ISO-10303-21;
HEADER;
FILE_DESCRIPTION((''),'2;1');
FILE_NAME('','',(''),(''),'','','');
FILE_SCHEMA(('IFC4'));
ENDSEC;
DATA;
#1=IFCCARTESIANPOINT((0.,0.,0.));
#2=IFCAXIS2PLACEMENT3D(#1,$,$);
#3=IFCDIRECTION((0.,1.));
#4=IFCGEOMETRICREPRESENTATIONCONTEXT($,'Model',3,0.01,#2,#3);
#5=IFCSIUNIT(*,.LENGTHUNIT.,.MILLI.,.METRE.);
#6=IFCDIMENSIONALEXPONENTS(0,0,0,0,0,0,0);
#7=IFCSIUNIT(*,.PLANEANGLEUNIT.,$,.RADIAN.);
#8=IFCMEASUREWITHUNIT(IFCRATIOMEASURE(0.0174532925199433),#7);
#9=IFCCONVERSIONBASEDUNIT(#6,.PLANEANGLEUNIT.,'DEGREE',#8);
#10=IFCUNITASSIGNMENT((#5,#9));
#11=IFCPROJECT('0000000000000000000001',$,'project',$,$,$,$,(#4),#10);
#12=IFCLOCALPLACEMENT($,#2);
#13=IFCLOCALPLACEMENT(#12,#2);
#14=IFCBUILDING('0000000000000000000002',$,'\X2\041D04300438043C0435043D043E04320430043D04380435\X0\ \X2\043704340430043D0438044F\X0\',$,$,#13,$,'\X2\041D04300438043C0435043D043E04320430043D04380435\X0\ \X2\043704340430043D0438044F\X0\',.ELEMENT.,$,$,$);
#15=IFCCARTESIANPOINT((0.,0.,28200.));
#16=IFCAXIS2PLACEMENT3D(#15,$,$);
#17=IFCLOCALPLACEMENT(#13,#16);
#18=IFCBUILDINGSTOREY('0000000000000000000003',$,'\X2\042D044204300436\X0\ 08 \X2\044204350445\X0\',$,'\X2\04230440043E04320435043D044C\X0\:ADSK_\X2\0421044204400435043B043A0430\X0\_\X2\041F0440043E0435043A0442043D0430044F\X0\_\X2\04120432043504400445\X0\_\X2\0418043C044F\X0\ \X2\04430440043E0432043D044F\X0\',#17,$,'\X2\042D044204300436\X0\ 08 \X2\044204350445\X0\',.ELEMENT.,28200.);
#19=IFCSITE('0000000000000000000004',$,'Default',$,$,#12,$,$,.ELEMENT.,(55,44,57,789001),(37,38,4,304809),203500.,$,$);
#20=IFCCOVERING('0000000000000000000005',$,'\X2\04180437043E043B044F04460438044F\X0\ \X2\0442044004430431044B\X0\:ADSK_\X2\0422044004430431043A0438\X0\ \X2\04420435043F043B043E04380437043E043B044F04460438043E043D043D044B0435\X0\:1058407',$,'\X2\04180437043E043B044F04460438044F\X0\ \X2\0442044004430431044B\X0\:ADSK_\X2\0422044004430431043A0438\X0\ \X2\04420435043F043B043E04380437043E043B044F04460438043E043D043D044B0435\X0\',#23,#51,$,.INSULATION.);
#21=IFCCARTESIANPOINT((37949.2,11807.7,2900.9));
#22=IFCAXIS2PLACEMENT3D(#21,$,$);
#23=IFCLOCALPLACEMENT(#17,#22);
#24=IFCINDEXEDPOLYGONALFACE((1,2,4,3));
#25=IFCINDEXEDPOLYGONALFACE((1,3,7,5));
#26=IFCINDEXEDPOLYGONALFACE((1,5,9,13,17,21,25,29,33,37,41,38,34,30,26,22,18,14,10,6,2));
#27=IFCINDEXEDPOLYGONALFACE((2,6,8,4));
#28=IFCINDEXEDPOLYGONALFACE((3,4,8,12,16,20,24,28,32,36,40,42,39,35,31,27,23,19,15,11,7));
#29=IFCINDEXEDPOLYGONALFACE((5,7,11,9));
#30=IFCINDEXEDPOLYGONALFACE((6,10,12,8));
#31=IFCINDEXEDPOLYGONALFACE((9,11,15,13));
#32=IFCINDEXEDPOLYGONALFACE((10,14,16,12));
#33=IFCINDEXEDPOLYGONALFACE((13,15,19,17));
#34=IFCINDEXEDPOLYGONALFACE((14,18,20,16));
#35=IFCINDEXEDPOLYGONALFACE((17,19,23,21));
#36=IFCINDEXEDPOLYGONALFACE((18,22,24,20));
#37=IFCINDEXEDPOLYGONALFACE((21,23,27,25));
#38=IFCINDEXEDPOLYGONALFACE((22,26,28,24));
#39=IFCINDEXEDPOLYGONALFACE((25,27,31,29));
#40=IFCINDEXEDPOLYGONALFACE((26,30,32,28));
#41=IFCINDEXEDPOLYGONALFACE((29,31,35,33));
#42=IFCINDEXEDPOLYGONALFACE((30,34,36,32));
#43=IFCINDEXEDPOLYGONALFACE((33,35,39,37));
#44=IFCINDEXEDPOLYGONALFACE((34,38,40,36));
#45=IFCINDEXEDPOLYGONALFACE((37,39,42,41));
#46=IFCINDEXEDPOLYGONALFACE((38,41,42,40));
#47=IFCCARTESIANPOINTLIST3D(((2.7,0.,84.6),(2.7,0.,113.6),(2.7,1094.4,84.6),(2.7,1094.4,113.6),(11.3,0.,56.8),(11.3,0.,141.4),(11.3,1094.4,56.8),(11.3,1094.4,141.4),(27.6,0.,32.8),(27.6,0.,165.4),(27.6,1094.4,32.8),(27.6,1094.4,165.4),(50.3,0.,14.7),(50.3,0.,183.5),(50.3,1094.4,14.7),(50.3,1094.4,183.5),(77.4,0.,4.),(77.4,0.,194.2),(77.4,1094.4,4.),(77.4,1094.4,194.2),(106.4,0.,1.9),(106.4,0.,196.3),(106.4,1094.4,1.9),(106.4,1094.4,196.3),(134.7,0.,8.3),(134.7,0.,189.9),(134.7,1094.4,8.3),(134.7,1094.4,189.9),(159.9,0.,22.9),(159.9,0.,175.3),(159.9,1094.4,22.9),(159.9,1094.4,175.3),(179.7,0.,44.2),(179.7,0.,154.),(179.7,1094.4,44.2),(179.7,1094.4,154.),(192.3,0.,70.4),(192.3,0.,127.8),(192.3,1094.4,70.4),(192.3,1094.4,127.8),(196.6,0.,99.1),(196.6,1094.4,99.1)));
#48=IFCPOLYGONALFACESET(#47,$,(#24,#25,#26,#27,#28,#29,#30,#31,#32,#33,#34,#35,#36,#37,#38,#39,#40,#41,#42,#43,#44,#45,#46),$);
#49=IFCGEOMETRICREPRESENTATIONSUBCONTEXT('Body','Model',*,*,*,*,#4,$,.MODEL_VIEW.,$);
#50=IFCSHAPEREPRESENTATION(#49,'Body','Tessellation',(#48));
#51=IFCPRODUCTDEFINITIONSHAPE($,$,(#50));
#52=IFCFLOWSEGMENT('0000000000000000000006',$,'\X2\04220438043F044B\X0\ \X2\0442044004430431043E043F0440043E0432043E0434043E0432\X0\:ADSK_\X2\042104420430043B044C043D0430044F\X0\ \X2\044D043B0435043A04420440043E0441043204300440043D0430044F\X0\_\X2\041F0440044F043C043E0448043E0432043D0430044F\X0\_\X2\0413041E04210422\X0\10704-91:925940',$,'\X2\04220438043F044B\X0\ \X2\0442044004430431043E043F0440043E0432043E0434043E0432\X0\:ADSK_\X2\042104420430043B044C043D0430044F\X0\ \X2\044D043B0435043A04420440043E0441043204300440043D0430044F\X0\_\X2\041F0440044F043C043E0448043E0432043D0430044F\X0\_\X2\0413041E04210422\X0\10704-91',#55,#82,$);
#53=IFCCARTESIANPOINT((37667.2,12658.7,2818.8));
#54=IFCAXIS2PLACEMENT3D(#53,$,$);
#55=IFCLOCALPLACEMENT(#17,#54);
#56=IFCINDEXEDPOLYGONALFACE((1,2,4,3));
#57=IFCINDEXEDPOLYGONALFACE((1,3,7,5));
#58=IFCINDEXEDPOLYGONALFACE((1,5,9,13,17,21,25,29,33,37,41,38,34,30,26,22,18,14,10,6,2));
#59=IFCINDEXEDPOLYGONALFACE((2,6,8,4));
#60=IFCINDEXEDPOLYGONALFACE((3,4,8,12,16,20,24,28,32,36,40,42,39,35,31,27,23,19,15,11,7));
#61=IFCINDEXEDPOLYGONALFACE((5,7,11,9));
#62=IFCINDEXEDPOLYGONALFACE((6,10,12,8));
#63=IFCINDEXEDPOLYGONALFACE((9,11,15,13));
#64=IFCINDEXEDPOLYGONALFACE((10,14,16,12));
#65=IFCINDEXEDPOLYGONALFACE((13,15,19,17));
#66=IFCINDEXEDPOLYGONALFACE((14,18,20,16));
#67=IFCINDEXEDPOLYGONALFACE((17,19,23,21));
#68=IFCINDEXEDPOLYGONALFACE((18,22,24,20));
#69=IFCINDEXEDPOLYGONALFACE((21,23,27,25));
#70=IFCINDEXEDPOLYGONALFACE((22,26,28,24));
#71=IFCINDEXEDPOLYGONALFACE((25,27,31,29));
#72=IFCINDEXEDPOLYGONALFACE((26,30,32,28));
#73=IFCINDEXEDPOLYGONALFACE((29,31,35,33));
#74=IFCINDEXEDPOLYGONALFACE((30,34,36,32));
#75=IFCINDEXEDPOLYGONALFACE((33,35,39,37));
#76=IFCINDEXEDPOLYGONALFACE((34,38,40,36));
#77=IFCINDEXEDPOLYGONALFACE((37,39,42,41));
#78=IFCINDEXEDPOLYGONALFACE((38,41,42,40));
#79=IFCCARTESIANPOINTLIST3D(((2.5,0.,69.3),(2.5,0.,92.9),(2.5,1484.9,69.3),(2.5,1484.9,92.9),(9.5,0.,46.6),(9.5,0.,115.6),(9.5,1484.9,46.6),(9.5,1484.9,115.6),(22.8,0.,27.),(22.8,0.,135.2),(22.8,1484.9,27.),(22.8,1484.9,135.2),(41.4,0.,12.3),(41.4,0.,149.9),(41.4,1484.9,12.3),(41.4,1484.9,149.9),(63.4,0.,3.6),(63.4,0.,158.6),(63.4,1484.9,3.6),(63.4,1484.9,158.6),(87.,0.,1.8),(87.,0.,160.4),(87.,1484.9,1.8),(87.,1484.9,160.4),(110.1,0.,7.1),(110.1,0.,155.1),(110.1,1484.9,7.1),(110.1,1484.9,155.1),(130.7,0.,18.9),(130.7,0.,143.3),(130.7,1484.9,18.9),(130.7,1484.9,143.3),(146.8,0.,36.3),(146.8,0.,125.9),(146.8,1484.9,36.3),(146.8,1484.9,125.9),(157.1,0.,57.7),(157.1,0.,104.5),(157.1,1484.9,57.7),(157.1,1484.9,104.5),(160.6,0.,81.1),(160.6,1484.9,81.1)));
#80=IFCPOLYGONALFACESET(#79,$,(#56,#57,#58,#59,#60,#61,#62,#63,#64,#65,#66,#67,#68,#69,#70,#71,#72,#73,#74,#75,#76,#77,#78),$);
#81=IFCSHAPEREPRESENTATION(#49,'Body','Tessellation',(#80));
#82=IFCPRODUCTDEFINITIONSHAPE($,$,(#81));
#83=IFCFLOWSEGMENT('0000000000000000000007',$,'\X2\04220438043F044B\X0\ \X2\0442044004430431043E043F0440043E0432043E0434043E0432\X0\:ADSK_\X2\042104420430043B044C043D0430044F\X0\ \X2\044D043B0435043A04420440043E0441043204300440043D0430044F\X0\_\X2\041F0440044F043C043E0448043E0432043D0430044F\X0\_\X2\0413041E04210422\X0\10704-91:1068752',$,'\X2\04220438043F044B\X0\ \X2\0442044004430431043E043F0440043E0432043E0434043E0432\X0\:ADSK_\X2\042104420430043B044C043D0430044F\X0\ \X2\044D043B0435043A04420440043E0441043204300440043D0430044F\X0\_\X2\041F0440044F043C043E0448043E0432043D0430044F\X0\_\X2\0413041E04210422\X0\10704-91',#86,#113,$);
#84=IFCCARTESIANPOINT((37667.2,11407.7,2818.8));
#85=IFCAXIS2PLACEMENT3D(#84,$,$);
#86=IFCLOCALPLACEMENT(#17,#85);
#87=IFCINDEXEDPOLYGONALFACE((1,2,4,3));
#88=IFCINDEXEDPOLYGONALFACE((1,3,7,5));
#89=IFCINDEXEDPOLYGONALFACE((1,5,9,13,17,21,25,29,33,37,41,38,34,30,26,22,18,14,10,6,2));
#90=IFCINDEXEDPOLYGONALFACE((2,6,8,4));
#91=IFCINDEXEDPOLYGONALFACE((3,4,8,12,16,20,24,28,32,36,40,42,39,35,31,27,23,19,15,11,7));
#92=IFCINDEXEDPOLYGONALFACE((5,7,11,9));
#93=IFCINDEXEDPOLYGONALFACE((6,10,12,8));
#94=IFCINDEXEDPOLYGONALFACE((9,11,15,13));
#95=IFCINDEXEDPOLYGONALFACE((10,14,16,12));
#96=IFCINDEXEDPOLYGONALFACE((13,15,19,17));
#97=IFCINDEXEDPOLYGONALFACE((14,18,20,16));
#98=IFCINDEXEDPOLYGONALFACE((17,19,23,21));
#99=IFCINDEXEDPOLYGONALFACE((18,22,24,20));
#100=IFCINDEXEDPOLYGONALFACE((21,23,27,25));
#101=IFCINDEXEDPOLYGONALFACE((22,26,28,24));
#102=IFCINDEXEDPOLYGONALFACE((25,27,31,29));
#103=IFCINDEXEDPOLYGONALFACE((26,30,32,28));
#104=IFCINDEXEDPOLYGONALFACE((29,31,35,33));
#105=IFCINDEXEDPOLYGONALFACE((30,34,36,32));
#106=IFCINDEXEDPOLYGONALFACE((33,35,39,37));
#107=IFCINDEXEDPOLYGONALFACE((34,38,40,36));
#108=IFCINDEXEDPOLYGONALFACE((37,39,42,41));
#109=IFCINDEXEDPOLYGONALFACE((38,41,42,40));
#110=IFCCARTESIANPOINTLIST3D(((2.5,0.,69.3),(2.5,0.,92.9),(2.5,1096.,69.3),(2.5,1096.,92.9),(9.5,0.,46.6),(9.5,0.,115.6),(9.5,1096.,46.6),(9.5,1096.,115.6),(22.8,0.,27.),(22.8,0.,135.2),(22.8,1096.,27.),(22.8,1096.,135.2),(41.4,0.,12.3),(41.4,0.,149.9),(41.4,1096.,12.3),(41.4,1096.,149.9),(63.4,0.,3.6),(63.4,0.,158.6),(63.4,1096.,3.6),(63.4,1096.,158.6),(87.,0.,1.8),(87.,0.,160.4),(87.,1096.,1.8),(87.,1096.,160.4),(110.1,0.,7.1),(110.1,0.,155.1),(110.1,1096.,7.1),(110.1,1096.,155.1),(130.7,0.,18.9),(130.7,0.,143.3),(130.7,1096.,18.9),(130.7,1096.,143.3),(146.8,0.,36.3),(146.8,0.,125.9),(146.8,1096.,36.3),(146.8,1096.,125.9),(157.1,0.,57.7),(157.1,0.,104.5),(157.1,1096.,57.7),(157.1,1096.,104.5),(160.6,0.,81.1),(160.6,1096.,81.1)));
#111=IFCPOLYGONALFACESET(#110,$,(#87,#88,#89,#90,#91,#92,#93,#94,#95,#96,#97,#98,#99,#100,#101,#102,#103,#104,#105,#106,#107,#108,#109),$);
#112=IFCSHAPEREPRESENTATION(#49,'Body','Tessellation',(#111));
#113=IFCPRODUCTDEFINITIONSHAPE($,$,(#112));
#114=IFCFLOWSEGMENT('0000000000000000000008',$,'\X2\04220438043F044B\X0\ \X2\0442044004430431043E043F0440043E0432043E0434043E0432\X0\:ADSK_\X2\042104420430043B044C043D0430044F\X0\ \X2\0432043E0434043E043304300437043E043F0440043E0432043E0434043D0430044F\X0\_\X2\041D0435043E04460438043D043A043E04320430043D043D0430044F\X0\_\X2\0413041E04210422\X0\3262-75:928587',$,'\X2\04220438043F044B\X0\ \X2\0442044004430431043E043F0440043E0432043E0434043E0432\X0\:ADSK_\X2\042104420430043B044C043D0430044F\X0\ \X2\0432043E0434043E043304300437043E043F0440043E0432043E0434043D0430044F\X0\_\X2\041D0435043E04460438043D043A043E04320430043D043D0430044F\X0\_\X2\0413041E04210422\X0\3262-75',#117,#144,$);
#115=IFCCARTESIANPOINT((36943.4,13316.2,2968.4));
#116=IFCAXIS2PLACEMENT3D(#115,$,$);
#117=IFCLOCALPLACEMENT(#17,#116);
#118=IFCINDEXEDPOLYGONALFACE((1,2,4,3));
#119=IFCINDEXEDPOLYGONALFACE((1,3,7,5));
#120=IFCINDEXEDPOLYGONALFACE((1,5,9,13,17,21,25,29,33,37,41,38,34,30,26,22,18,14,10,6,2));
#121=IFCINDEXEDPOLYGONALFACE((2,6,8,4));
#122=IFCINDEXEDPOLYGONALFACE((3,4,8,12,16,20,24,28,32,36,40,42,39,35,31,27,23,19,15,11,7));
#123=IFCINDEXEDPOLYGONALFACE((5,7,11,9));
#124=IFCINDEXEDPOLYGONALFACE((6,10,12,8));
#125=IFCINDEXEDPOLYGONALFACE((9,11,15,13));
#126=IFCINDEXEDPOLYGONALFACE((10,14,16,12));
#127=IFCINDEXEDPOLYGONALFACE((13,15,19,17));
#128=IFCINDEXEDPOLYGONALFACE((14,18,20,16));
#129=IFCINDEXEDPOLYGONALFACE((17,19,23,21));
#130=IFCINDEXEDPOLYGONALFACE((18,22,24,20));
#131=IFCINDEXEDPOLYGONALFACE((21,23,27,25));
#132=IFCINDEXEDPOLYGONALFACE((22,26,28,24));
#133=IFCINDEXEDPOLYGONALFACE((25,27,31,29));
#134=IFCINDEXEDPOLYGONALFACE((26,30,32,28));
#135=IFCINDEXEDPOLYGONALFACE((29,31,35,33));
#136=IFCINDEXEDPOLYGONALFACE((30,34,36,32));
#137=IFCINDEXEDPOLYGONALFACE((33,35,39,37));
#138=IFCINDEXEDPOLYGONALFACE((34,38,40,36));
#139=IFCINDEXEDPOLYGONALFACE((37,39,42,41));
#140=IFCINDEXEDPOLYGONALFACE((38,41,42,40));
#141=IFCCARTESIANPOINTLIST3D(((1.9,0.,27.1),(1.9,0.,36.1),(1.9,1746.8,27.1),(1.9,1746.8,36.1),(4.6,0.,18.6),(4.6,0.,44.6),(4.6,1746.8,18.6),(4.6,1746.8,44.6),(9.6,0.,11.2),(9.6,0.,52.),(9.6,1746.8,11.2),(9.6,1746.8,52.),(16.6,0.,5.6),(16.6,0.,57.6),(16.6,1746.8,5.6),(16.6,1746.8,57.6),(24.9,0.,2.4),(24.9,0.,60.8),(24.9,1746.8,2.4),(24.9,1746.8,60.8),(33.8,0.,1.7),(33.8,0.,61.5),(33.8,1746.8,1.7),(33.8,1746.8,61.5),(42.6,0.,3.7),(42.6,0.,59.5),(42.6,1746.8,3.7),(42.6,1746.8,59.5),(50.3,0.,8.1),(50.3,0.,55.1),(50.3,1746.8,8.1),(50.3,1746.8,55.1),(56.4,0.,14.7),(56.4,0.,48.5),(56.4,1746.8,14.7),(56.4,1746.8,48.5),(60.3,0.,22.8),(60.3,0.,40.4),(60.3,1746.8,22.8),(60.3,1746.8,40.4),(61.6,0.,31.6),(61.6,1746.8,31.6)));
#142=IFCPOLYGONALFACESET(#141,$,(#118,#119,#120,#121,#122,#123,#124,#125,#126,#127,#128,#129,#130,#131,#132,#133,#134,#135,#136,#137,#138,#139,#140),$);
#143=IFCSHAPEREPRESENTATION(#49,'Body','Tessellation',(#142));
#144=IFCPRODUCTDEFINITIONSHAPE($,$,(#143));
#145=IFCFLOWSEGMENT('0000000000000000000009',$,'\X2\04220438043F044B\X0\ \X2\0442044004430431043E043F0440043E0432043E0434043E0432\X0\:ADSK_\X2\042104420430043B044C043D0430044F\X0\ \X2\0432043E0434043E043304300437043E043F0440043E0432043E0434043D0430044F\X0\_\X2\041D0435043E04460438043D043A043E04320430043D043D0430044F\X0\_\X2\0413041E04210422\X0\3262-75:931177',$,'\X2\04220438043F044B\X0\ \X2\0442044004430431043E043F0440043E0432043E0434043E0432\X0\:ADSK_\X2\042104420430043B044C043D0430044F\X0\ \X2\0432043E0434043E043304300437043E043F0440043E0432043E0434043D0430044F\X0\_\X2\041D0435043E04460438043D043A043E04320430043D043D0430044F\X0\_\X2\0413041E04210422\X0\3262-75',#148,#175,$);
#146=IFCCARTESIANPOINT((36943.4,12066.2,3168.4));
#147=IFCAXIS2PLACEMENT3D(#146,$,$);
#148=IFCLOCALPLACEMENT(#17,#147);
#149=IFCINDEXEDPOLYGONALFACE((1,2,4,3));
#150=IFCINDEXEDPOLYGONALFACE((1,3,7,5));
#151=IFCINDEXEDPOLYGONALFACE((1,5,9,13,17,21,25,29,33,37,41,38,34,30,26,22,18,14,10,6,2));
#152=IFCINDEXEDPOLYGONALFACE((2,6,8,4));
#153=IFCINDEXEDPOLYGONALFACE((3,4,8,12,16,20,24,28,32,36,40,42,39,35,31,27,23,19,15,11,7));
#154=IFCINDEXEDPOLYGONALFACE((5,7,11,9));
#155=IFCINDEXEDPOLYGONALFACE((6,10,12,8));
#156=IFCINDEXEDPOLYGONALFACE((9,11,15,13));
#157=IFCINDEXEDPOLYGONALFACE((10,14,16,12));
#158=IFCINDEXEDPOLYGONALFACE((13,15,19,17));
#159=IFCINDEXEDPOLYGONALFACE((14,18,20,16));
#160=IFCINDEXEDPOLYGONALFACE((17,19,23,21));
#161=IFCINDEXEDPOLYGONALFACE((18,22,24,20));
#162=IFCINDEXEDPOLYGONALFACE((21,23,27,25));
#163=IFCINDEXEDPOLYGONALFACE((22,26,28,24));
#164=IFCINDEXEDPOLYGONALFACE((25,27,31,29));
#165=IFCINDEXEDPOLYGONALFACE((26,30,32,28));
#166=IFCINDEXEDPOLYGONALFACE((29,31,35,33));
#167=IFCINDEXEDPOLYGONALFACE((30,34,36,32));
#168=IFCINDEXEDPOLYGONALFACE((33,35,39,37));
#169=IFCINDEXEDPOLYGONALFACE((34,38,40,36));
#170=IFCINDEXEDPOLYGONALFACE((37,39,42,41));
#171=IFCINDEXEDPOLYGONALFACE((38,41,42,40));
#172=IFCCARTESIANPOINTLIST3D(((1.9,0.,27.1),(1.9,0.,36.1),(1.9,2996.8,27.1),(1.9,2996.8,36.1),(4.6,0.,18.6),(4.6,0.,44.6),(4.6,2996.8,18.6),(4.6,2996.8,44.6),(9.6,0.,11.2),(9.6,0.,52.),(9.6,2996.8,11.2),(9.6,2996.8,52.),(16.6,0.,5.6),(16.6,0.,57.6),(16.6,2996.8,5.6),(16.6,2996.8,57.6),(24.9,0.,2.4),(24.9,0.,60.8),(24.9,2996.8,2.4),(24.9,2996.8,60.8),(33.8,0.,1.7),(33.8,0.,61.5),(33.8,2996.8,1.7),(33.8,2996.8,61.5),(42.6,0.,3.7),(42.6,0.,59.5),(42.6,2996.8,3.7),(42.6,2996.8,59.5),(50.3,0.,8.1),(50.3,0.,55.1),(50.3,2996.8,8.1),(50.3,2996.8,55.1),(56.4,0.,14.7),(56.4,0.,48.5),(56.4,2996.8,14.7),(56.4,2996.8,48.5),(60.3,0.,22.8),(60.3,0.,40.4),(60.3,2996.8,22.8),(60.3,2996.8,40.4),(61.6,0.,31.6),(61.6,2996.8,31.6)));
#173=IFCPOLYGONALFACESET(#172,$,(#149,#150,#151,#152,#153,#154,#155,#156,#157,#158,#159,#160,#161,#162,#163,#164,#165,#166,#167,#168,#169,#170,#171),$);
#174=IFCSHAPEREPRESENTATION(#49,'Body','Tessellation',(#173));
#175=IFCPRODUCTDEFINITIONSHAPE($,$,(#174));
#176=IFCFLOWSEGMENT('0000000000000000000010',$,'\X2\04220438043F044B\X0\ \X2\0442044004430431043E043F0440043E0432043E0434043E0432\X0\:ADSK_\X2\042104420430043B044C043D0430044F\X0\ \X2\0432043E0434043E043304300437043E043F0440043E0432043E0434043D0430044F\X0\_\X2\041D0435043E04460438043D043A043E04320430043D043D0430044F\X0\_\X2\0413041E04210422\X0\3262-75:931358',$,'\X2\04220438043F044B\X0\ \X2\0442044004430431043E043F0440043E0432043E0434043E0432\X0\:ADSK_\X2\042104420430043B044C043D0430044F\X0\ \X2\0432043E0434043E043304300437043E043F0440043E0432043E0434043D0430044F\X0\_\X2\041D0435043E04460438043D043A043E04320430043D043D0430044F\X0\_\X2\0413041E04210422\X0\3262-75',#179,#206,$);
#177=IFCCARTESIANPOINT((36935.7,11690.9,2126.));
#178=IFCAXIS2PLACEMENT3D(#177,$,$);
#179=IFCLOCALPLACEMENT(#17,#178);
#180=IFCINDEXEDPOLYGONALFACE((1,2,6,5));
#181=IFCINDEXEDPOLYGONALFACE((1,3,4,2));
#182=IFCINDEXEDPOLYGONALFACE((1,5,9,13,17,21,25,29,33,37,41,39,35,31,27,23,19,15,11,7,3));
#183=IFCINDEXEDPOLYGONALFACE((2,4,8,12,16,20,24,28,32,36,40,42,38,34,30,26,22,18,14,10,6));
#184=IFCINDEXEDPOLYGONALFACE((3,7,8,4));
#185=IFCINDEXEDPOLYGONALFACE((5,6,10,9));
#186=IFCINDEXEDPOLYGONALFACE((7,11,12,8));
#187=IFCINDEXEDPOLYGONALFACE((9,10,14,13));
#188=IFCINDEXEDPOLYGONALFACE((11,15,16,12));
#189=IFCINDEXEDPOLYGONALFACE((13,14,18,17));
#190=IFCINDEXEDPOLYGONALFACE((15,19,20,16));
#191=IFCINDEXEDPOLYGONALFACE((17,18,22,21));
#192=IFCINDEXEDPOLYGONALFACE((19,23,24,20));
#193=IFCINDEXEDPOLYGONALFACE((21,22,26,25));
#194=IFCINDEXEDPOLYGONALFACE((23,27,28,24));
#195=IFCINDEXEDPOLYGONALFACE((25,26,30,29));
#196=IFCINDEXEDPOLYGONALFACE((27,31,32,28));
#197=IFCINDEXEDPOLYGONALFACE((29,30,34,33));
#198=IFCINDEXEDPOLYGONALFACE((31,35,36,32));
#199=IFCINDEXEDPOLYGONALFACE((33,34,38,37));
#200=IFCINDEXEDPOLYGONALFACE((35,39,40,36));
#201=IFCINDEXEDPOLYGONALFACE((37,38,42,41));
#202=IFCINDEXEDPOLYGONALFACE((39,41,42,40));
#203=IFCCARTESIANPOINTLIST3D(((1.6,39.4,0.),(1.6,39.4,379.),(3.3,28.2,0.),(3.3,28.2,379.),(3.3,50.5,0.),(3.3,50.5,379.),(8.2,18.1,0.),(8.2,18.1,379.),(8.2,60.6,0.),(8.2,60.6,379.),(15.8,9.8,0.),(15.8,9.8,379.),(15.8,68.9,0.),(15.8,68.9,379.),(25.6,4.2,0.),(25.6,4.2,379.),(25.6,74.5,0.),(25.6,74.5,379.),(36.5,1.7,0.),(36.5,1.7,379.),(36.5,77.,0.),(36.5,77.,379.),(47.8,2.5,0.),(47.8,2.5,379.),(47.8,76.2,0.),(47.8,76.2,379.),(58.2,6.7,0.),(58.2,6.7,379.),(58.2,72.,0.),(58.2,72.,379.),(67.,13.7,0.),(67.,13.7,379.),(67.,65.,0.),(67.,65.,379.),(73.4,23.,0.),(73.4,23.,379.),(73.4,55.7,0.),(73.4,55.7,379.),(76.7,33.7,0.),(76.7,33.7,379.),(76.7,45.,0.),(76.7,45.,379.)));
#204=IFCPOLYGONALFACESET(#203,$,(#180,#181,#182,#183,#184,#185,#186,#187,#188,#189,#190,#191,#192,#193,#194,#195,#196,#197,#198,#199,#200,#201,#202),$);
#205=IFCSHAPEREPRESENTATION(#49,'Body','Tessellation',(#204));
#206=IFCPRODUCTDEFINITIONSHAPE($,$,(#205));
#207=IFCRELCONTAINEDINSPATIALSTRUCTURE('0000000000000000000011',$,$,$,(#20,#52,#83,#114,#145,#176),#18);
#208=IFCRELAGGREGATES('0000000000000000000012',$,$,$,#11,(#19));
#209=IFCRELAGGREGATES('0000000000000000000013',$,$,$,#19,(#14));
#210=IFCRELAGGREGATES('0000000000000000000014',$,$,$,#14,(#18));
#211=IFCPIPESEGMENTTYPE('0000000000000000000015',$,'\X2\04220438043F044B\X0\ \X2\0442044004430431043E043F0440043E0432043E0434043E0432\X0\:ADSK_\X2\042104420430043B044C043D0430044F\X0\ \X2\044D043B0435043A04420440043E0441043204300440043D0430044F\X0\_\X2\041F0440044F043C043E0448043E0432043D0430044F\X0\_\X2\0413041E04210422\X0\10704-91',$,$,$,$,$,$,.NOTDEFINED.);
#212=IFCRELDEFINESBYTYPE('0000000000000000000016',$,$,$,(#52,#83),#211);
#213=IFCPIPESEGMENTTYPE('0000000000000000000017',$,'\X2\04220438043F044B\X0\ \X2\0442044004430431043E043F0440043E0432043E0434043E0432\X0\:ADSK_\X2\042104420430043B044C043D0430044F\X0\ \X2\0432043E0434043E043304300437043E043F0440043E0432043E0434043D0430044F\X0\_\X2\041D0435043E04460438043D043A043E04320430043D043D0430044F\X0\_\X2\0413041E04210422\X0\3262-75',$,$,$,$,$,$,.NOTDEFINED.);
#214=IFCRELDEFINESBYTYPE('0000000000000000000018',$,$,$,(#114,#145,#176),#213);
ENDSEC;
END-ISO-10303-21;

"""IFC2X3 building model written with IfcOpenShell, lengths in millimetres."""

from ifc_helpers import new_model, entity, si_unit, converted_unit, direction, frame, origin, origin_2d_with_axis, place, context, subcontext, project, spatial, circle, extrude, type_object, element, save


model = new_model("IFC2X3")

# Units and contexts
model_context = context("Model", 3, precision=0.01, world=origin(), true_north=direction((0.0, 1.0)))
body_context = subcontext(model_context, "Body", "Model", "MODEL_VIEW")
ifc_project = project(units=[si_unit("LENGTHUNIT", "METRE", prefix="MILLI"), converted_unit("PLANEANGLEUNIT", "DEGREE", entity("IfcRatioMeasure", 0.0174532925199433), si_unit("PLANEANGLEUNIT", "RADIAN"), dimensions=[0, 0, 0, 0, 0, 0, 0])], contexts=[model_context])

# Site, building, storey
site_placement = place(None, origin())
site = spatial("IfcSite", under=ifc_project, at=site_placement, Name="Default", CompositionType="ELEMENT", RefLatitude=(55, 44, 57, 789001), RefLongitude=(37, 38, 4, 304809), RefElevation=203500.0)
building_placement = place(site_placement, origin())
building = spatial("IfcBuilding", under=site, at=building_placement, Name="Наименование здания", LongName="Наименование здания", CompositionType="ELEMENT")
storey_placement = place(building_placement, frame((0.0, 0.0, 28200.0)))
storey = spatial("IfcBuildingStorey", under=building, at=storey_placement, Name="Этаж 08 тех", ObjectType="Уровень:ADSK_Стрелка_Проектная_Вверх_Имя уровня", LongName="Этаж 08 тех", CompositionType="ELEMENT", Elevation=28200.0)

# Covering
covering_1_placement = place(storey_placement, frame((37949.2, 11807.7, 2900.9)))
element("IfcCovering", 1, at=covering_1_placement, inside=storey, Name="Изоляция трубы:ADSK_Трубки теплоизоляционные:1058407", ObjectType="Изоляция трубы:ADSK_Трубки теплоизоляционные", PredefinedType="INSULATION", context=body_context, shape_type="SweptSolid", body=[
    extrude(circle(Radius=97.5, at=origin_2d_with_axis()), frame((99.1, 0.0, 99.1), z_axis=(0.0, 1.0, 0.0), x_axis=(1.0, 0.0, 0.0)), (0.0, 0.0, 1.0), 1094.4),
])

# Flow segments
pipe_segment_type_1 = type_object("IfcPipeSegmentType", Name="Типы трубопроводов:ADSK_Стальная электросварная_Прямошовная_ГОСТ10704-91", PredefinedType="NOTDEFINED")
flow_segment_1_placement = place(storey_placement, frame((37667.2, 12658.7, 2818.8)))
element("IfcFlowSegment", 2, at=flow_segment_1_placement, inside=storey, type_object=pipe_segment_type_1, Name="Типы трубопроводов:ADSK_Стальная электросварная_Прямошовная_ГОСТ10704-91:925940", ObjectType="Типы трубопроводов:ADSK_Стальная электросварная_Прямошовная_ГОСТ10704-91", context=body_context, shape_type="SweptSolid", body=[
    extrude(circle(Radius=79.5, at=origin_2d_with_axis()), frame((81.1, 0.0, 81.1), z_axis=(0.0, 1.0, 0.0), x_axis=(1.0, 0.0, 0.0)), (0.0, 0.0, 1.0), 1484.9),
])
flow_segment_2_placement = place(storey_placement, frame((37667.2, 11407.7, 2818.8)))
element("IfcFlowSegment", 3, at=flow_segment_2_placement, inside=storey, type_object=pipe_segment_type_1, Name="Типы трубопроводов:ADSK_Стальная электросварная_Прямошовная_ГОСТ10704-91:1068752", ObjectType="Типы трубопроводов:ADSK_Стальная электросварная_Прямошовная_ГОСТ10704-91", context=body_context, shape_type="SweptSolid", body=[
    extrude(circle(Radius=79.5, at=origin_2d_with_axis()), frame((81.1, 0.0, 81.1), z_axis=(0.0, 1.0, 0.0), x_axis=(1.0, 0.0, 0.0)), (0.0, 0.0, 1.0), 1096.0),
])
pipe_segment_type_2 = type_object("IfcPipeSegmentType", Name="Типы трубопроводов:ADSK_Стальная водогазопроводная_Неоцинкованная_ГОСТ3262-75", PredefinedType="NOTDEFINED")
flow_segment_3_placement = place(storey_placement, frame((36943.4, 13316.2, 2968.4)))
element("IfcFlowSegment", 4, at=flow_segment_3_placement, inside=storey, type_object=pipe_segment_type_2, Name="Типы трубопроводов:ADSK_Стальная водогазопроводная_Неоцинкованная_ГОСТ3262-75:928587", ObjectType="Типы трубопроводов:ADSK_Стальная водогазопроводная_Неоцинкованная_ГОСТ3262-75", context=body_context, shape_type="SweptSolid", body=[
    extrude(circle(Radius=30.0, at=origin_2d_with_axis()), frame((31.6, 0.0, 31.6), z_axis=(0.0, 1.0, 0.0), x_axis=(1.0, 0.0, 0.0)), (0.0, 0.0, 1.0), 1746.8),
])
flow_segment_4_placement = place(storey_placement, frame((36943.4, 12066.2, 3168.4)))
element("IfcFlowSegment", 5, at=flow_segment_4_placement, inside=storey, type_object=pipe_segment_type_2, Name="Типы трубопроводов:ADSK_Стальная водогазопроводная_Неоцинкованная_ГОСТ3262-75:931177", ObjectType="Типы трубопроводов:ADSK_Стальная водогазопроводная_Неоцинкованная_ГОСТ3262-75", context=body_context, shape_type="SweptSolid", body=[
    extrude(circle(Radius=30.0, at=origin_2d_with_axis()), frame((31.6, 0.0, 31.6), z_axis=(0.0, 1.0, 0.0), x_axis=(1.0, 0.0, 0.0)), (0.0, 0.0, 1.0), 2996.8),
])
flow_segment_5_placement = place(storey_placement, frame((36935.7, 11690.9, 2126.0)))
element("IfcFlowSegment", 6, at=flow_segment_5_placement, inside=storey, type_object=pipe_segment_type_2, Name="Типы трубопроводов:ADSK_Стальная водогазопроводная_Неоцинкованная_ГОСТ3262-75:931358", ObjectType="Типы трубопроводов:ADSK_Стальная водогазопроводная_Неоцинкованная_ГОСТ3262-75", context=body_context, shape_type="SweptSolid", body=[
    extrude(circle(Radius=37.8, at=origin_2d_with_axis()), frame((39.4, 39.4, 0.0), z_axis=(0.0, 0.0, 1.0), x_axis=(-1.0, 0.0, 0.0)), (0.0, 0.0, 1.0), 379.0),
])

save(model, "model.ifc")
